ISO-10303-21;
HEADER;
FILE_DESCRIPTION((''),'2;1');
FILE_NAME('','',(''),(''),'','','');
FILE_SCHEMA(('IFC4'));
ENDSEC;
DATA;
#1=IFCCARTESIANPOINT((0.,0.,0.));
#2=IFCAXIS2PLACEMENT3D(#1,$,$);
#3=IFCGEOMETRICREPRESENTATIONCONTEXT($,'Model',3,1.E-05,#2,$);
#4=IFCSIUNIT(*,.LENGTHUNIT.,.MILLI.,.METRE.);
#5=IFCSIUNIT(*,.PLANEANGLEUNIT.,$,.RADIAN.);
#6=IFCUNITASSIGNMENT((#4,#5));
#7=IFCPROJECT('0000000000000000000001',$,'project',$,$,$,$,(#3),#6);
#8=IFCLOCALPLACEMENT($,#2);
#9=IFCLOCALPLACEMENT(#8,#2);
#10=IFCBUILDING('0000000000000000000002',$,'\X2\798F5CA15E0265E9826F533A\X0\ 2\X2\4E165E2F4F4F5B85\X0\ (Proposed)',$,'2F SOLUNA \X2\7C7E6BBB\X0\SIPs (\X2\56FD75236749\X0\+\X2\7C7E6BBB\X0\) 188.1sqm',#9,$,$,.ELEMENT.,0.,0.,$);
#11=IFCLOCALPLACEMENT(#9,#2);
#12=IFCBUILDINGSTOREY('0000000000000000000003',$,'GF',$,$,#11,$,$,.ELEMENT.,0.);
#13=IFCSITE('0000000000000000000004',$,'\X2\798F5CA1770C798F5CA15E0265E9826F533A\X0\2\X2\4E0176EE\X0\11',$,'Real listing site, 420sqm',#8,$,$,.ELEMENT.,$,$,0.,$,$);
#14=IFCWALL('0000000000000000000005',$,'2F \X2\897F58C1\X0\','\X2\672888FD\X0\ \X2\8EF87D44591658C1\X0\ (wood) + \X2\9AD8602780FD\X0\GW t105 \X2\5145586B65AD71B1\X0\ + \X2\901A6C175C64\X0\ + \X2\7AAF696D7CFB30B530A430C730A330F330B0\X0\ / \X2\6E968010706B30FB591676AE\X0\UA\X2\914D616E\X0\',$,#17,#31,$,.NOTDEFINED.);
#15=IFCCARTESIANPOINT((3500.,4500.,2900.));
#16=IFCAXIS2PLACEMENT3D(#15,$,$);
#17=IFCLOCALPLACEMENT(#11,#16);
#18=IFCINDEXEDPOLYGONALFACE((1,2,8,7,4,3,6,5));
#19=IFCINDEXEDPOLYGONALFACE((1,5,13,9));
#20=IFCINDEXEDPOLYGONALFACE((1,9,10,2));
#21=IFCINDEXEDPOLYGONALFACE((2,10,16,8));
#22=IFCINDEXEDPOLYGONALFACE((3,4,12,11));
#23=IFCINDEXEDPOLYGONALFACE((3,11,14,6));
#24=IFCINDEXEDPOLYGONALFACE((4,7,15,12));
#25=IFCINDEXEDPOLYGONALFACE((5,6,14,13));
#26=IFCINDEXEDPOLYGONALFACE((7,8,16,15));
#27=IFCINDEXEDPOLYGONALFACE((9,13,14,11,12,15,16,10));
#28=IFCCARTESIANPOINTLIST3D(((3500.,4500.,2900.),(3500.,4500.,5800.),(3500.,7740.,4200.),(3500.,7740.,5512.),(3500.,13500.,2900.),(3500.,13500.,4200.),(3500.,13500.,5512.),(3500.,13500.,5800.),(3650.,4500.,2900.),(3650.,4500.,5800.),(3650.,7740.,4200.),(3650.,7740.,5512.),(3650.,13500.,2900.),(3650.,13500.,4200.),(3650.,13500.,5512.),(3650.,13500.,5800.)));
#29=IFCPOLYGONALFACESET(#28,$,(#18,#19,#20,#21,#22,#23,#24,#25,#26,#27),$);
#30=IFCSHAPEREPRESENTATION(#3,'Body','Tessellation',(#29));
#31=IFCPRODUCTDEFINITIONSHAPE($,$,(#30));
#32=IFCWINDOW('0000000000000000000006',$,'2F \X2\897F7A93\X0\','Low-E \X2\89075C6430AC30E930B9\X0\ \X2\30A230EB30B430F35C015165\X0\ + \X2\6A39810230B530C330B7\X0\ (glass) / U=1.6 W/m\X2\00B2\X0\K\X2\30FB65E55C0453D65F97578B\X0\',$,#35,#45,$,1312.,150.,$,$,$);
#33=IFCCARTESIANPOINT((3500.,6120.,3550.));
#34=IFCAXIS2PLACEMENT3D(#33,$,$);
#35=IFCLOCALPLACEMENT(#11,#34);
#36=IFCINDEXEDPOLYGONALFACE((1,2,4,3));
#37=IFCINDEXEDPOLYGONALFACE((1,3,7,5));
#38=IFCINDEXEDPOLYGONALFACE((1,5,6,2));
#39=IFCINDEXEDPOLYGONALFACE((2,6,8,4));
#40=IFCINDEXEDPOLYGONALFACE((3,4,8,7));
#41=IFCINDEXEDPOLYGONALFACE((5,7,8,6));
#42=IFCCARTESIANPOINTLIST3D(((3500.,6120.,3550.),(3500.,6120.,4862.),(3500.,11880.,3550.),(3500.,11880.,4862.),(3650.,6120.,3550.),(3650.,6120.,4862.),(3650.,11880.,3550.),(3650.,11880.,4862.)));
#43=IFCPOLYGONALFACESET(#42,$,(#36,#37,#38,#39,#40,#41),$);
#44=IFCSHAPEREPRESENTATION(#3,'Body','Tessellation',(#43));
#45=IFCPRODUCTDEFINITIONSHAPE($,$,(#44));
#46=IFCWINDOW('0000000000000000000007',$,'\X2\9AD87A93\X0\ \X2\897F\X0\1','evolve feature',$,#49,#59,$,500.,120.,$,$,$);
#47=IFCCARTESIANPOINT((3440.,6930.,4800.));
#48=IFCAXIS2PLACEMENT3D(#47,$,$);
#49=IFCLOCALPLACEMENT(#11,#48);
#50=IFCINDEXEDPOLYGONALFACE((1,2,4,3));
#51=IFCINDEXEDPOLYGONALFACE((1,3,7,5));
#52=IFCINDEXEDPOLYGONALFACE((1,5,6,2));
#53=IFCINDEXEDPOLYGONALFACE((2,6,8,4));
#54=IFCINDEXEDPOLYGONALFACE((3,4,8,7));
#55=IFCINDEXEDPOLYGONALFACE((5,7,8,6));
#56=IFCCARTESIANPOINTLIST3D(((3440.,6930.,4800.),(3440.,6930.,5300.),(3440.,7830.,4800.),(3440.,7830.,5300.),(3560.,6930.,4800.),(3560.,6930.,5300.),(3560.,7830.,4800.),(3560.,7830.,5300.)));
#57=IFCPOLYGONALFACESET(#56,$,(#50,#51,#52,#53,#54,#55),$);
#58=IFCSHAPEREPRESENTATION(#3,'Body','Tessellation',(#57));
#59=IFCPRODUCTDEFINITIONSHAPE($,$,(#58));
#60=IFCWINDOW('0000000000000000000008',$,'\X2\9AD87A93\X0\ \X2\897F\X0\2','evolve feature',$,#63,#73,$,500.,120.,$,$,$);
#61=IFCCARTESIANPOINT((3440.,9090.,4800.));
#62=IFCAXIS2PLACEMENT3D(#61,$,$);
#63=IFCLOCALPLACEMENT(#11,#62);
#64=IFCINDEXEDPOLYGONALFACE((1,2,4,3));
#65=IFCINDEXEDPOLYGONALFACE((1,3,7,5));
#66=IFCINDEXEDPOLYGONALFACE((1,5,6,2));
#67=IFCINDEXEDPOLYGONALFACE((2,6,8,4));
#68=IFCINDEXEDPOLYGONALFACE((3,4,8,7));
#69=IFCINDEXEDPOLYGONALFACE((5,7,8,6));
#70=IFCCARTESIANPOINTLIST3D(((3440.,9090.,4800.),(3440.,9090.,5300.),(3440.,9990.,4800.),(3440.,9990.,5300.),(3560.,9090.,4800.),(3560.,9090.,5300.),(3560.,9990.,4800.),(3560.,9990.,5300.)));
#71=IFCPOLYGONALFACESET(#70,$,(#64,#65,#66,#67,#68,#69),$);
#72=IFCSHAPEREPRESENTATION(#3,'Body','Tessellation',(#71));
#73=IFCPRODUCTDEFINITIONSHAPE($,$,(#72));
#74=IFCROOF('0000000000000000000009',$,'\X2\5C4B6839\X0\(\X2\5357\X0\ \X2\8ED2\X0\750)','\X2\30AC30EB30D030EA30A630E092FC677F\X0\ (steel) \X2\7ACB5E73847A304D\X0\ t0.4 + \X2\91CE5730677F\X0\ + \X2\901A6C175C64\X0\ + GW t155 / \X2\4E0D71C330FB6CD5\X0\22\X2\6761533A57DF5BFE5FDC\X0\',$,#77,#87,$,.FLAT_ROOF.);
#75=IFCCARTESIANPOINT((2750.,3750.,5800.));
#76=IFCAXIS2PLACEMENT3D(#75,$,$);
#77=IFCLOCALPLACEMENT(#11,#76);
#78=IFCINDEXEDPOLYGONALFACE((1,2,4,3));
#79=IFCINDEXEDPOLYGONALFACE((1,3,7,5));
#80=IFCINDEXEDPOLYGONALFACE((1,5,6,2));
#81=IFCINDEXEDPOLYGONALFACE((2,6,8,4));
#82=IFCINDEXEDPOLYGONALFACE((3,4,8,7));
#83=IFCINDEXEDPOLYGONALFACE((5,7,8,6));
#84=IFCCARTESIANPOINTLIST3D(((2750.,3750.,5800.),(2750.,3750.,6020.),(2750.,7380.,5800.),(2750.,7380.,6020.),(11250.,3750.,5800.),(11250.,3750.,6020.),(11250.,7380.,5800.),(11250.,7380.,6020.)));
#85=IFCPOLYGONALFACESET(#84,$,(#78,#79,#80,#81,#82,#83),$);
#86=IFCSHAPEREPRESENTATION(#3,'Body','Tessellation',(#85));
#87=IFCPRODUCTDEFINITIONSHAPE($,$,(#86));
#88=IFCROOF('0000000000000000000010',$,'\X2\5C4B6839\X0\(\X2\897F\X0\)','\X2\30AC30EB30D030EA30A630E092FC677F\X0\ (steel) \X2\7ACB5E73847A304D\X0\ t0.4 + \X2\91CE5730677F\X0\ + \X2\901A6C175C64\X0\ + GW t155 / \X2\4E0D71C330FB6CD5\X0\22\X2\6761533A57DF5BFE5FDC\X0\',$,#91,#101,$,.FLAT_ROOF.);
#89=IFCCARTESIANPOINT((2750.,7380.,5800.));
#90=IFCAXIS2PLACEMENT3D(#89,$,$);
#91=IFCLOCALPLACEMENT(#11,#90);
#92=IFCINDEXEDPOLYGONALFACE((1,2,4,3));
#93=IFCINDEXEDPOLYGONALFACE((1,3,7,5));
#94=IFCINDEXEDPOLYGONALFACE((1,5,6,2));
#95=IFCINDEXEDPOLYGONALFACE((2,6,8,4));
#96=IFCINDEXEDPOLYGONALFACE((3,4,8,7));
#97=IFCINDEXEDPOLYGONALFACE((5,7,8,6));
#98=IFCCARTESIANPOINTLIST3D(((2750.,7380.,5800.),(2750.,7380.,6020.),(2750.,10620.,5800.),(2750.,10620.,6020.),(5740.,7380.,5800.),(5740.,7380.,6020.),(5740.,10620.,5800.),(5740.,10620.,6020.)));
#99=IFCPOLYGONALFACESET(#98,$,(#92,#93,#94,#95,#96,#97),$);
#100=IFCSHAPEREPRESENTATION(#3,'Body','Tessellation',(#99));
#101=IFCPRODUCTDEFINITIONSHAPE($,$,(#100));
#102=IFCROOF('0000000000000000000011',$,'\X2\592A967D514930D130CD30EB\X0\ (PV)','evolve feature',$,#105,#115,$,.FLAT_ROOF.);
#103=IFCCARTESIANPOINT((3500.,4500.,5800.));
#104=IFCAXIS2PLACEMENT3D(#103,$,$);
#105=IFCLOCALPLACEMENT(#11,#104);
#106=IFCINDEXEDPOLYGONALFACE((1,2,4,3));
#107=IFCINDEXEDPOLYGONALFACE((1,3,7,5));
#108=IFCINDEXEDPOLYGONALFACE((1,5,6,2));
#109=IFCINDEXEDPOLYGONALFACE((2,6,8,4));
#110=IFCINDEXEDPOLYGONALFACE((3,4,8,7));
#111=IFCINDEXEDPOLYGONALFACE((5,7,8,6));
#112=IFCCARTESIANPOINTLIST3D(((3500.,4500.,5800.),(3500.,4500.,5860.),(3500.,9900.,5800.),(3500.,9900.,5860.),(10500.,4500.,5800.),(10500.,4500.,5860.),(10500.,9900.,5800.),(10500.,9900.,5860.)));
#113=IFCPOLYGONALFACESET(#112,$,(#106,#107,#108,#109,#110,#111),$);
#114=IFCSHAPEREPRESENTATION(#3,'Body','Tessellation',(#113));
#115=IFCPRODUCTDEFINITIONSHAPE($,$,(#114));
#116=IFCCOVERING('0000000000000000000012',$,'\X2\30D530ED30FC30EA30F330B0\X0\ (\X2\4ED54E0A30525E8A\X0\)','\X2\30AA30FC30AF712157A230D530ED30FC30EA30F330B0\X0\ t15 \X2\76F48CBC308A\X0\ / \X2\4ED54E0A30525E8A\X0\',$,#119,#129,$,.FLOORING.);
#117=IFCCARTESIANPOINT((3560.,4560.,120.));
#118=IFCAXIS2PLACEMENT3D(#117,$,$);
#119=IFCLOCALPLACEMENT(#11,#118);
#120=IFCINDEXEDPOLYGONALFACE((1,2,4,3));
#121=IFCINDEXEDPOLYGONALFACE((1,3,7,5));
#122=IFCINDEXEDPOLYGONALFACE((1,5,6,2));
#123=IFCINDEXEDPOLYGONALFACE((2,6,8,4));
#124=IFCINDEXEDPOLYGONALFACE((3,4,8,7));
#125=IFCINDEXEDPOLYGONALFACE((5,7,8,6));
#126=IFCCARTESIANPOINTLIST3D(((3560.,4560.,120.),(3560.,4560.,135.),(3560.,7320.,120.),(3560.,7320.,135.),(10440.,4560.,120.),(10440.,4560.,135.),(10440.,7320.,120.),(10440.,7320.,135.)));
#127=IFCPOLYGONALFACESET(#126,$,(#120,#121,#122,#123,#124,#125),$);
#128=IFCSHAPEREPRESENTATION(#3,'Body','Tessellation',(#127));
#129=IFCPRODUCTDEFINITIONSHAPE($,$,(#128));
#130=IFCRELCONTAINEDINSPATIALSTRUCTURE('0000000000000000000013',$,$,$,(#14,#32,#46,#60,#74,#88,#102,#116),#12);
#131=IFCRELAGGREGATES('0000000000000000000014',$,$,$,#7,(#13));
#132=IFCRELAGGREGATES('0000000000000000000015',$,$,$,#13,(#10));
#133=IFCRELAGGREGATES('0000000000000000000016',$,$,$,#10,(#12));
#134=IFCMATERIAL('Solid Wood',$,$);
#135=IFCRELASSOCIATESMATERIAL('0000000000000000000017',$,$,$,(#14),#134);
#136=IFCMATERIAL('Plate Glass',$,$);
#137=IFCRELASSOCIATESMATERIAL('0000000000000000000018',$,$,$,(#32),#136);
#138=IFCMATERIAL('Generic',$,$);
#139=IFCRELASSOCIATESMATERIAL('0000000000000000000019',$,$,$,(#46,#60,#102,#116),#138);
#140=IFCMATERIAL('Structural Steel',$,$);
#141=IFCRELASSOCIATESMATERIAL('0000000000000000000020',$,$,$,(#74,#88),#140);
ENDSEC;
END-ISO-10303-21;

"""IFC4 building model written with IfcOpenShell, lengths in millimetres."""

from ifc_helpers import new_model, si_unit, frame, frame_2d, origin, place, context, project, spatial, rectangle, extrude, material, element, fill, save


model = new_model("IFC4")

# Units and contexts
model_context = context("Model", 3, precision=1e-05, world=origin())
ifc_project = project(units=[si_unit("LENGTHUNIT", "METRE", prefix="MILLI"), si_unit("PLANEANGLEUNIT", "RADIAN")], contexts=[model_context])

# Site, building, storey
site_placement = place(None, origin())
site = spatial("IfcSite", under=ifc_project, at=site_placement, Name="福岡県福岡市早良区2丁目11", ObjectType="Real listing site, 420sqm", CompositionType="ELEMENT", RefElevation=0.0)
building_placement = place(site_placement, origin())
building = spatial("IfcBuilding", under=site, at=building_placement, Name="福岡市早良区 2世帯住宅 (Proposed)", ObjectType="2F SOLUNA 籾殻SIPs (国産杉+籾殻) 188.1sqm", CompositionType="ELEMENT", ElevationOfRefHeight=0.0, ElevationOfTerrain=0.0)
storey_placement = place(building_placement, origin())
storey = spatial("IfcBuildingStorey", under=building, at=storey_placement, Name="GF", CompositionType="ELEMENT", Elevation=0.0)

# Shared definitions
ifc_material_1 = material(Name="Solid Wood")
ifc_material_2 = material(Name="Generic")

# Shared definitions
ifc_material_3 = material(Name="Plate Glass")

# Wall, openings, windows
wall_1_placement = place(storey_placement, frame((3500.0, 4500.0, 2900.0)))
wall_1 = element("IfcWall", 1, at=wall_1_placement, inside=storey, material=ifc_material_1, Name="2F 西壁", Description="木製 軸組外壁 (wood) + 高性能GW t105 充填断熱 + 通気層 + 窯業系サイディング / 準耐火・外皮UA配慮", PredefinedType="NOTDEFINED", context=model_context, shape_type="SweptSolid", body=[
    extrude(rectangle(XDim=150.0, YDim=9000.0, at=frame_2d((75.0, 4500.0))), frame((3500.0, 4500.0, 2900.0)), (0.0, 0.0, 1.0), 2900.0),
])
opening_1_placement = place(storey_placement, frame((3500.0, 6120.0, 3550.0)))
opening_1 = element("IfcOpeningElement", 2, at=opening_1_placement, cuts=wall_1, PredefinedType="NOTDEFINED", context=model_context, shape_type="SweptSolid", body=[
    extrude(rectangle(XDim=150.0, YDim=5760.0, at=frame_2d((75.0, 2880.0))), frame((3500.0, 6120.0, 3550.0)), (0.0, 0.0, 1.0), 1312.0),
])
opening_2_placement = place(storey_placement, frame((3440.0, 6930.0, 4800.0)))
opening_2 = element("IfcOpeningElement", 3, at=opening_2_placement, cuts=wall_1, PredefinedType="NOTDEFINED", context=model_context, shape_type="SweptSolid", body=[
    extrude(rectangle(XDim=120.0, YDim=900.0, at=frame_2d((60.0, 450.0))), frame((3440.0, 6930.0, 4800.0)), (0.0, 0.0, 1.0), 500.0),
])
opening_3_placement = place(storey_placement, frame((3440.0, 9090.0, 4800.0)))
opening_3 = element("IfcOpeningElement", 4, at=opening_3_placement, cuts=wall_1, PredefinedType="NOTDEFINED", context=model_context, shape_type="SweptSolid", body=[
    extrude(rectangle(XDim=120.0, YDim=900.0, at=frame_2d((60.0, 450.0))), frame((3440.0, 9090.0, 4800.0)), (0.0, 0.0, 1.0), 500.0),
])
window_1_placement = place(storey_placement, frame((3500.0, 6120.0, 3550.0)))
window_1 = element("IfcWindow", 5, at=window_1_placement, inside=storey, material=ifc_material_3, Name="2F 西窓", Description="Low-E 複層ガラス アルゴン封入 + 樹脂サッシ (glass) / U=1.6 W/m²K・日射取得型", OverallHeight=1312.0, OverallWidth=150.0, context=model_context, shape_type="SweptSolid", body=[
    extrude(rectangle(XDim=150.0, YDim=5760.0, at=frame_2d((75.0, 2880.0))), frame((3500.0, 6120.0, 3550.0)), (0.0, 0.0, 1.0), 1312.0),
])
fill(opening_1, window_1)
window_2_placement = place(storey_placement, frame((3440.0, 6930.0, 4800.0)))
window_2 = element("IfcWindow", 6, at=window_2_placement, inside=storey, material=ifc_material_2, Name="高窓 西1", Description="evolve feature", OverallHeight=500.0, OverallWidth=120.0, context=model_context, shape_type="SweptSolid", body=[
    extrude(rectangle(XDim=120.0, YDim=900.0, at=frame_2d((60.0, 450.0))), frame((3440.0, 6930.0, 4800.0)), (0.0, 0.0, 1.0), 500.0),
])
fill(opening_2, window_2)
window_3_placement = place(storey_placement, frame((3440.0, 9090.0, 4800.0)))
window_3 = element("IfcWindow", 7, at=window_3_placement, inside=storey, material=ifc_material_2, Name="高窓 西2", Description="evolve feature", OverallHeight=500.0, OverallWidth=120.0, context=model_context, shape_type="SweptSolid", body=[
    extrude(rectangle(XDim=120.0, YDim=900.0, at=frame_2d((60.0, 450.0))), frame((3440.0, 9090.0, 4800.0)), (0.0, 0.0, 1.0), 500.0),
])
fill(opening_3, window_3)

# Roofs
ifc_material_4 = material(Name="Structural Steel")
roof_1_placement = place(storey_placement, frame((2750.0, 3750.0, 5800.0)))
element("IfcRoof", 8, at=roof_1_placement, inside=storey, material=ifc_material_4, Name="屋根(南 軒750)", Description="ガルバリウム鋼板 (steel) 立平葺き t0.4 + 野地板 + 通気層 + GW t155 / 不燃・法22条区域対応", PredefinedType="FLAT_ROOF", context=model_context, shape_type="SweptSolid", body=[
    extrude(rectangle(XDim=8500.0, YDim=3630.0, at=frame_2d((4250.0, 1815.0))), frame((2750.0, 3750.0, 5800.0)), (0.0, 0.0, 1.0), 220.0),
])
roof_2_placement = place(storey_placement, frame((2750.0, 7380.0, 5800.0)))
element("IfcRoof", 9, at=roof_2_placement, inside=storey, material=ifc_material_4, Name="屋根(西)", Description="ガルバリウム鋼板 (steel) 立平葺き t0.4 + 野地板 + 通気層 + GW t155 / 不燃・法22条区域対応", PredefinedType="FLAT_ROOF", context=model_context, shape_type="SweptSolid", body=[
    extrude(rectangle(XDim=2990.0, YDim=3240.0, at=frame_2d((1495.0, 1620.0))), frame((2750.0, 7380.0, 5800.0)), (0.0, 0.0, 1.0), 220.0),
])
roof_3_placement = place(storey_placement, frame((3500.0, 4500.0, 5800.0)))
element("IfcRoof", 10, at=roof_3_placement, inside=storey, material=ifc_material_2, Name="太陽光パネル (PV)", Description="evolve feature", PredefinedType="FLAT_ROOF", context=model_context, shape_type="SweptSolid", body=[
    extrude(rectangle(XDim=7000.0, YDim=5400.0, at=frame_2d((3500.0, 2700.0))), frame((3500.0, 4500.0, 5800.0)), (0.0, 0.0, 1.0), 60.0),
])

# Covering
covering_placement = place(storey_placement, frame((3560.0, 4560.0, 120.0)))
element("IfcCovering", 11, at=covering_placement, inside=storey, material=ifc_material_2, Name="フローリング (仕上げ床)", Description="オーク無垢フローリング t15 直貼り / 仕上げ床", PredefinedType="FLOORING", context=model_context, shape_type="SweptSolid", body=[
    extrude(rectangle(XDim=6880.0, YDim=2760.0, at=frame_2d((3440.0, 1380.0))), frame((3560.0, 4560.0, 120.0)), (0.0, 0.0, 1.0), 15.0),
])

save(model, "model.ifc")
